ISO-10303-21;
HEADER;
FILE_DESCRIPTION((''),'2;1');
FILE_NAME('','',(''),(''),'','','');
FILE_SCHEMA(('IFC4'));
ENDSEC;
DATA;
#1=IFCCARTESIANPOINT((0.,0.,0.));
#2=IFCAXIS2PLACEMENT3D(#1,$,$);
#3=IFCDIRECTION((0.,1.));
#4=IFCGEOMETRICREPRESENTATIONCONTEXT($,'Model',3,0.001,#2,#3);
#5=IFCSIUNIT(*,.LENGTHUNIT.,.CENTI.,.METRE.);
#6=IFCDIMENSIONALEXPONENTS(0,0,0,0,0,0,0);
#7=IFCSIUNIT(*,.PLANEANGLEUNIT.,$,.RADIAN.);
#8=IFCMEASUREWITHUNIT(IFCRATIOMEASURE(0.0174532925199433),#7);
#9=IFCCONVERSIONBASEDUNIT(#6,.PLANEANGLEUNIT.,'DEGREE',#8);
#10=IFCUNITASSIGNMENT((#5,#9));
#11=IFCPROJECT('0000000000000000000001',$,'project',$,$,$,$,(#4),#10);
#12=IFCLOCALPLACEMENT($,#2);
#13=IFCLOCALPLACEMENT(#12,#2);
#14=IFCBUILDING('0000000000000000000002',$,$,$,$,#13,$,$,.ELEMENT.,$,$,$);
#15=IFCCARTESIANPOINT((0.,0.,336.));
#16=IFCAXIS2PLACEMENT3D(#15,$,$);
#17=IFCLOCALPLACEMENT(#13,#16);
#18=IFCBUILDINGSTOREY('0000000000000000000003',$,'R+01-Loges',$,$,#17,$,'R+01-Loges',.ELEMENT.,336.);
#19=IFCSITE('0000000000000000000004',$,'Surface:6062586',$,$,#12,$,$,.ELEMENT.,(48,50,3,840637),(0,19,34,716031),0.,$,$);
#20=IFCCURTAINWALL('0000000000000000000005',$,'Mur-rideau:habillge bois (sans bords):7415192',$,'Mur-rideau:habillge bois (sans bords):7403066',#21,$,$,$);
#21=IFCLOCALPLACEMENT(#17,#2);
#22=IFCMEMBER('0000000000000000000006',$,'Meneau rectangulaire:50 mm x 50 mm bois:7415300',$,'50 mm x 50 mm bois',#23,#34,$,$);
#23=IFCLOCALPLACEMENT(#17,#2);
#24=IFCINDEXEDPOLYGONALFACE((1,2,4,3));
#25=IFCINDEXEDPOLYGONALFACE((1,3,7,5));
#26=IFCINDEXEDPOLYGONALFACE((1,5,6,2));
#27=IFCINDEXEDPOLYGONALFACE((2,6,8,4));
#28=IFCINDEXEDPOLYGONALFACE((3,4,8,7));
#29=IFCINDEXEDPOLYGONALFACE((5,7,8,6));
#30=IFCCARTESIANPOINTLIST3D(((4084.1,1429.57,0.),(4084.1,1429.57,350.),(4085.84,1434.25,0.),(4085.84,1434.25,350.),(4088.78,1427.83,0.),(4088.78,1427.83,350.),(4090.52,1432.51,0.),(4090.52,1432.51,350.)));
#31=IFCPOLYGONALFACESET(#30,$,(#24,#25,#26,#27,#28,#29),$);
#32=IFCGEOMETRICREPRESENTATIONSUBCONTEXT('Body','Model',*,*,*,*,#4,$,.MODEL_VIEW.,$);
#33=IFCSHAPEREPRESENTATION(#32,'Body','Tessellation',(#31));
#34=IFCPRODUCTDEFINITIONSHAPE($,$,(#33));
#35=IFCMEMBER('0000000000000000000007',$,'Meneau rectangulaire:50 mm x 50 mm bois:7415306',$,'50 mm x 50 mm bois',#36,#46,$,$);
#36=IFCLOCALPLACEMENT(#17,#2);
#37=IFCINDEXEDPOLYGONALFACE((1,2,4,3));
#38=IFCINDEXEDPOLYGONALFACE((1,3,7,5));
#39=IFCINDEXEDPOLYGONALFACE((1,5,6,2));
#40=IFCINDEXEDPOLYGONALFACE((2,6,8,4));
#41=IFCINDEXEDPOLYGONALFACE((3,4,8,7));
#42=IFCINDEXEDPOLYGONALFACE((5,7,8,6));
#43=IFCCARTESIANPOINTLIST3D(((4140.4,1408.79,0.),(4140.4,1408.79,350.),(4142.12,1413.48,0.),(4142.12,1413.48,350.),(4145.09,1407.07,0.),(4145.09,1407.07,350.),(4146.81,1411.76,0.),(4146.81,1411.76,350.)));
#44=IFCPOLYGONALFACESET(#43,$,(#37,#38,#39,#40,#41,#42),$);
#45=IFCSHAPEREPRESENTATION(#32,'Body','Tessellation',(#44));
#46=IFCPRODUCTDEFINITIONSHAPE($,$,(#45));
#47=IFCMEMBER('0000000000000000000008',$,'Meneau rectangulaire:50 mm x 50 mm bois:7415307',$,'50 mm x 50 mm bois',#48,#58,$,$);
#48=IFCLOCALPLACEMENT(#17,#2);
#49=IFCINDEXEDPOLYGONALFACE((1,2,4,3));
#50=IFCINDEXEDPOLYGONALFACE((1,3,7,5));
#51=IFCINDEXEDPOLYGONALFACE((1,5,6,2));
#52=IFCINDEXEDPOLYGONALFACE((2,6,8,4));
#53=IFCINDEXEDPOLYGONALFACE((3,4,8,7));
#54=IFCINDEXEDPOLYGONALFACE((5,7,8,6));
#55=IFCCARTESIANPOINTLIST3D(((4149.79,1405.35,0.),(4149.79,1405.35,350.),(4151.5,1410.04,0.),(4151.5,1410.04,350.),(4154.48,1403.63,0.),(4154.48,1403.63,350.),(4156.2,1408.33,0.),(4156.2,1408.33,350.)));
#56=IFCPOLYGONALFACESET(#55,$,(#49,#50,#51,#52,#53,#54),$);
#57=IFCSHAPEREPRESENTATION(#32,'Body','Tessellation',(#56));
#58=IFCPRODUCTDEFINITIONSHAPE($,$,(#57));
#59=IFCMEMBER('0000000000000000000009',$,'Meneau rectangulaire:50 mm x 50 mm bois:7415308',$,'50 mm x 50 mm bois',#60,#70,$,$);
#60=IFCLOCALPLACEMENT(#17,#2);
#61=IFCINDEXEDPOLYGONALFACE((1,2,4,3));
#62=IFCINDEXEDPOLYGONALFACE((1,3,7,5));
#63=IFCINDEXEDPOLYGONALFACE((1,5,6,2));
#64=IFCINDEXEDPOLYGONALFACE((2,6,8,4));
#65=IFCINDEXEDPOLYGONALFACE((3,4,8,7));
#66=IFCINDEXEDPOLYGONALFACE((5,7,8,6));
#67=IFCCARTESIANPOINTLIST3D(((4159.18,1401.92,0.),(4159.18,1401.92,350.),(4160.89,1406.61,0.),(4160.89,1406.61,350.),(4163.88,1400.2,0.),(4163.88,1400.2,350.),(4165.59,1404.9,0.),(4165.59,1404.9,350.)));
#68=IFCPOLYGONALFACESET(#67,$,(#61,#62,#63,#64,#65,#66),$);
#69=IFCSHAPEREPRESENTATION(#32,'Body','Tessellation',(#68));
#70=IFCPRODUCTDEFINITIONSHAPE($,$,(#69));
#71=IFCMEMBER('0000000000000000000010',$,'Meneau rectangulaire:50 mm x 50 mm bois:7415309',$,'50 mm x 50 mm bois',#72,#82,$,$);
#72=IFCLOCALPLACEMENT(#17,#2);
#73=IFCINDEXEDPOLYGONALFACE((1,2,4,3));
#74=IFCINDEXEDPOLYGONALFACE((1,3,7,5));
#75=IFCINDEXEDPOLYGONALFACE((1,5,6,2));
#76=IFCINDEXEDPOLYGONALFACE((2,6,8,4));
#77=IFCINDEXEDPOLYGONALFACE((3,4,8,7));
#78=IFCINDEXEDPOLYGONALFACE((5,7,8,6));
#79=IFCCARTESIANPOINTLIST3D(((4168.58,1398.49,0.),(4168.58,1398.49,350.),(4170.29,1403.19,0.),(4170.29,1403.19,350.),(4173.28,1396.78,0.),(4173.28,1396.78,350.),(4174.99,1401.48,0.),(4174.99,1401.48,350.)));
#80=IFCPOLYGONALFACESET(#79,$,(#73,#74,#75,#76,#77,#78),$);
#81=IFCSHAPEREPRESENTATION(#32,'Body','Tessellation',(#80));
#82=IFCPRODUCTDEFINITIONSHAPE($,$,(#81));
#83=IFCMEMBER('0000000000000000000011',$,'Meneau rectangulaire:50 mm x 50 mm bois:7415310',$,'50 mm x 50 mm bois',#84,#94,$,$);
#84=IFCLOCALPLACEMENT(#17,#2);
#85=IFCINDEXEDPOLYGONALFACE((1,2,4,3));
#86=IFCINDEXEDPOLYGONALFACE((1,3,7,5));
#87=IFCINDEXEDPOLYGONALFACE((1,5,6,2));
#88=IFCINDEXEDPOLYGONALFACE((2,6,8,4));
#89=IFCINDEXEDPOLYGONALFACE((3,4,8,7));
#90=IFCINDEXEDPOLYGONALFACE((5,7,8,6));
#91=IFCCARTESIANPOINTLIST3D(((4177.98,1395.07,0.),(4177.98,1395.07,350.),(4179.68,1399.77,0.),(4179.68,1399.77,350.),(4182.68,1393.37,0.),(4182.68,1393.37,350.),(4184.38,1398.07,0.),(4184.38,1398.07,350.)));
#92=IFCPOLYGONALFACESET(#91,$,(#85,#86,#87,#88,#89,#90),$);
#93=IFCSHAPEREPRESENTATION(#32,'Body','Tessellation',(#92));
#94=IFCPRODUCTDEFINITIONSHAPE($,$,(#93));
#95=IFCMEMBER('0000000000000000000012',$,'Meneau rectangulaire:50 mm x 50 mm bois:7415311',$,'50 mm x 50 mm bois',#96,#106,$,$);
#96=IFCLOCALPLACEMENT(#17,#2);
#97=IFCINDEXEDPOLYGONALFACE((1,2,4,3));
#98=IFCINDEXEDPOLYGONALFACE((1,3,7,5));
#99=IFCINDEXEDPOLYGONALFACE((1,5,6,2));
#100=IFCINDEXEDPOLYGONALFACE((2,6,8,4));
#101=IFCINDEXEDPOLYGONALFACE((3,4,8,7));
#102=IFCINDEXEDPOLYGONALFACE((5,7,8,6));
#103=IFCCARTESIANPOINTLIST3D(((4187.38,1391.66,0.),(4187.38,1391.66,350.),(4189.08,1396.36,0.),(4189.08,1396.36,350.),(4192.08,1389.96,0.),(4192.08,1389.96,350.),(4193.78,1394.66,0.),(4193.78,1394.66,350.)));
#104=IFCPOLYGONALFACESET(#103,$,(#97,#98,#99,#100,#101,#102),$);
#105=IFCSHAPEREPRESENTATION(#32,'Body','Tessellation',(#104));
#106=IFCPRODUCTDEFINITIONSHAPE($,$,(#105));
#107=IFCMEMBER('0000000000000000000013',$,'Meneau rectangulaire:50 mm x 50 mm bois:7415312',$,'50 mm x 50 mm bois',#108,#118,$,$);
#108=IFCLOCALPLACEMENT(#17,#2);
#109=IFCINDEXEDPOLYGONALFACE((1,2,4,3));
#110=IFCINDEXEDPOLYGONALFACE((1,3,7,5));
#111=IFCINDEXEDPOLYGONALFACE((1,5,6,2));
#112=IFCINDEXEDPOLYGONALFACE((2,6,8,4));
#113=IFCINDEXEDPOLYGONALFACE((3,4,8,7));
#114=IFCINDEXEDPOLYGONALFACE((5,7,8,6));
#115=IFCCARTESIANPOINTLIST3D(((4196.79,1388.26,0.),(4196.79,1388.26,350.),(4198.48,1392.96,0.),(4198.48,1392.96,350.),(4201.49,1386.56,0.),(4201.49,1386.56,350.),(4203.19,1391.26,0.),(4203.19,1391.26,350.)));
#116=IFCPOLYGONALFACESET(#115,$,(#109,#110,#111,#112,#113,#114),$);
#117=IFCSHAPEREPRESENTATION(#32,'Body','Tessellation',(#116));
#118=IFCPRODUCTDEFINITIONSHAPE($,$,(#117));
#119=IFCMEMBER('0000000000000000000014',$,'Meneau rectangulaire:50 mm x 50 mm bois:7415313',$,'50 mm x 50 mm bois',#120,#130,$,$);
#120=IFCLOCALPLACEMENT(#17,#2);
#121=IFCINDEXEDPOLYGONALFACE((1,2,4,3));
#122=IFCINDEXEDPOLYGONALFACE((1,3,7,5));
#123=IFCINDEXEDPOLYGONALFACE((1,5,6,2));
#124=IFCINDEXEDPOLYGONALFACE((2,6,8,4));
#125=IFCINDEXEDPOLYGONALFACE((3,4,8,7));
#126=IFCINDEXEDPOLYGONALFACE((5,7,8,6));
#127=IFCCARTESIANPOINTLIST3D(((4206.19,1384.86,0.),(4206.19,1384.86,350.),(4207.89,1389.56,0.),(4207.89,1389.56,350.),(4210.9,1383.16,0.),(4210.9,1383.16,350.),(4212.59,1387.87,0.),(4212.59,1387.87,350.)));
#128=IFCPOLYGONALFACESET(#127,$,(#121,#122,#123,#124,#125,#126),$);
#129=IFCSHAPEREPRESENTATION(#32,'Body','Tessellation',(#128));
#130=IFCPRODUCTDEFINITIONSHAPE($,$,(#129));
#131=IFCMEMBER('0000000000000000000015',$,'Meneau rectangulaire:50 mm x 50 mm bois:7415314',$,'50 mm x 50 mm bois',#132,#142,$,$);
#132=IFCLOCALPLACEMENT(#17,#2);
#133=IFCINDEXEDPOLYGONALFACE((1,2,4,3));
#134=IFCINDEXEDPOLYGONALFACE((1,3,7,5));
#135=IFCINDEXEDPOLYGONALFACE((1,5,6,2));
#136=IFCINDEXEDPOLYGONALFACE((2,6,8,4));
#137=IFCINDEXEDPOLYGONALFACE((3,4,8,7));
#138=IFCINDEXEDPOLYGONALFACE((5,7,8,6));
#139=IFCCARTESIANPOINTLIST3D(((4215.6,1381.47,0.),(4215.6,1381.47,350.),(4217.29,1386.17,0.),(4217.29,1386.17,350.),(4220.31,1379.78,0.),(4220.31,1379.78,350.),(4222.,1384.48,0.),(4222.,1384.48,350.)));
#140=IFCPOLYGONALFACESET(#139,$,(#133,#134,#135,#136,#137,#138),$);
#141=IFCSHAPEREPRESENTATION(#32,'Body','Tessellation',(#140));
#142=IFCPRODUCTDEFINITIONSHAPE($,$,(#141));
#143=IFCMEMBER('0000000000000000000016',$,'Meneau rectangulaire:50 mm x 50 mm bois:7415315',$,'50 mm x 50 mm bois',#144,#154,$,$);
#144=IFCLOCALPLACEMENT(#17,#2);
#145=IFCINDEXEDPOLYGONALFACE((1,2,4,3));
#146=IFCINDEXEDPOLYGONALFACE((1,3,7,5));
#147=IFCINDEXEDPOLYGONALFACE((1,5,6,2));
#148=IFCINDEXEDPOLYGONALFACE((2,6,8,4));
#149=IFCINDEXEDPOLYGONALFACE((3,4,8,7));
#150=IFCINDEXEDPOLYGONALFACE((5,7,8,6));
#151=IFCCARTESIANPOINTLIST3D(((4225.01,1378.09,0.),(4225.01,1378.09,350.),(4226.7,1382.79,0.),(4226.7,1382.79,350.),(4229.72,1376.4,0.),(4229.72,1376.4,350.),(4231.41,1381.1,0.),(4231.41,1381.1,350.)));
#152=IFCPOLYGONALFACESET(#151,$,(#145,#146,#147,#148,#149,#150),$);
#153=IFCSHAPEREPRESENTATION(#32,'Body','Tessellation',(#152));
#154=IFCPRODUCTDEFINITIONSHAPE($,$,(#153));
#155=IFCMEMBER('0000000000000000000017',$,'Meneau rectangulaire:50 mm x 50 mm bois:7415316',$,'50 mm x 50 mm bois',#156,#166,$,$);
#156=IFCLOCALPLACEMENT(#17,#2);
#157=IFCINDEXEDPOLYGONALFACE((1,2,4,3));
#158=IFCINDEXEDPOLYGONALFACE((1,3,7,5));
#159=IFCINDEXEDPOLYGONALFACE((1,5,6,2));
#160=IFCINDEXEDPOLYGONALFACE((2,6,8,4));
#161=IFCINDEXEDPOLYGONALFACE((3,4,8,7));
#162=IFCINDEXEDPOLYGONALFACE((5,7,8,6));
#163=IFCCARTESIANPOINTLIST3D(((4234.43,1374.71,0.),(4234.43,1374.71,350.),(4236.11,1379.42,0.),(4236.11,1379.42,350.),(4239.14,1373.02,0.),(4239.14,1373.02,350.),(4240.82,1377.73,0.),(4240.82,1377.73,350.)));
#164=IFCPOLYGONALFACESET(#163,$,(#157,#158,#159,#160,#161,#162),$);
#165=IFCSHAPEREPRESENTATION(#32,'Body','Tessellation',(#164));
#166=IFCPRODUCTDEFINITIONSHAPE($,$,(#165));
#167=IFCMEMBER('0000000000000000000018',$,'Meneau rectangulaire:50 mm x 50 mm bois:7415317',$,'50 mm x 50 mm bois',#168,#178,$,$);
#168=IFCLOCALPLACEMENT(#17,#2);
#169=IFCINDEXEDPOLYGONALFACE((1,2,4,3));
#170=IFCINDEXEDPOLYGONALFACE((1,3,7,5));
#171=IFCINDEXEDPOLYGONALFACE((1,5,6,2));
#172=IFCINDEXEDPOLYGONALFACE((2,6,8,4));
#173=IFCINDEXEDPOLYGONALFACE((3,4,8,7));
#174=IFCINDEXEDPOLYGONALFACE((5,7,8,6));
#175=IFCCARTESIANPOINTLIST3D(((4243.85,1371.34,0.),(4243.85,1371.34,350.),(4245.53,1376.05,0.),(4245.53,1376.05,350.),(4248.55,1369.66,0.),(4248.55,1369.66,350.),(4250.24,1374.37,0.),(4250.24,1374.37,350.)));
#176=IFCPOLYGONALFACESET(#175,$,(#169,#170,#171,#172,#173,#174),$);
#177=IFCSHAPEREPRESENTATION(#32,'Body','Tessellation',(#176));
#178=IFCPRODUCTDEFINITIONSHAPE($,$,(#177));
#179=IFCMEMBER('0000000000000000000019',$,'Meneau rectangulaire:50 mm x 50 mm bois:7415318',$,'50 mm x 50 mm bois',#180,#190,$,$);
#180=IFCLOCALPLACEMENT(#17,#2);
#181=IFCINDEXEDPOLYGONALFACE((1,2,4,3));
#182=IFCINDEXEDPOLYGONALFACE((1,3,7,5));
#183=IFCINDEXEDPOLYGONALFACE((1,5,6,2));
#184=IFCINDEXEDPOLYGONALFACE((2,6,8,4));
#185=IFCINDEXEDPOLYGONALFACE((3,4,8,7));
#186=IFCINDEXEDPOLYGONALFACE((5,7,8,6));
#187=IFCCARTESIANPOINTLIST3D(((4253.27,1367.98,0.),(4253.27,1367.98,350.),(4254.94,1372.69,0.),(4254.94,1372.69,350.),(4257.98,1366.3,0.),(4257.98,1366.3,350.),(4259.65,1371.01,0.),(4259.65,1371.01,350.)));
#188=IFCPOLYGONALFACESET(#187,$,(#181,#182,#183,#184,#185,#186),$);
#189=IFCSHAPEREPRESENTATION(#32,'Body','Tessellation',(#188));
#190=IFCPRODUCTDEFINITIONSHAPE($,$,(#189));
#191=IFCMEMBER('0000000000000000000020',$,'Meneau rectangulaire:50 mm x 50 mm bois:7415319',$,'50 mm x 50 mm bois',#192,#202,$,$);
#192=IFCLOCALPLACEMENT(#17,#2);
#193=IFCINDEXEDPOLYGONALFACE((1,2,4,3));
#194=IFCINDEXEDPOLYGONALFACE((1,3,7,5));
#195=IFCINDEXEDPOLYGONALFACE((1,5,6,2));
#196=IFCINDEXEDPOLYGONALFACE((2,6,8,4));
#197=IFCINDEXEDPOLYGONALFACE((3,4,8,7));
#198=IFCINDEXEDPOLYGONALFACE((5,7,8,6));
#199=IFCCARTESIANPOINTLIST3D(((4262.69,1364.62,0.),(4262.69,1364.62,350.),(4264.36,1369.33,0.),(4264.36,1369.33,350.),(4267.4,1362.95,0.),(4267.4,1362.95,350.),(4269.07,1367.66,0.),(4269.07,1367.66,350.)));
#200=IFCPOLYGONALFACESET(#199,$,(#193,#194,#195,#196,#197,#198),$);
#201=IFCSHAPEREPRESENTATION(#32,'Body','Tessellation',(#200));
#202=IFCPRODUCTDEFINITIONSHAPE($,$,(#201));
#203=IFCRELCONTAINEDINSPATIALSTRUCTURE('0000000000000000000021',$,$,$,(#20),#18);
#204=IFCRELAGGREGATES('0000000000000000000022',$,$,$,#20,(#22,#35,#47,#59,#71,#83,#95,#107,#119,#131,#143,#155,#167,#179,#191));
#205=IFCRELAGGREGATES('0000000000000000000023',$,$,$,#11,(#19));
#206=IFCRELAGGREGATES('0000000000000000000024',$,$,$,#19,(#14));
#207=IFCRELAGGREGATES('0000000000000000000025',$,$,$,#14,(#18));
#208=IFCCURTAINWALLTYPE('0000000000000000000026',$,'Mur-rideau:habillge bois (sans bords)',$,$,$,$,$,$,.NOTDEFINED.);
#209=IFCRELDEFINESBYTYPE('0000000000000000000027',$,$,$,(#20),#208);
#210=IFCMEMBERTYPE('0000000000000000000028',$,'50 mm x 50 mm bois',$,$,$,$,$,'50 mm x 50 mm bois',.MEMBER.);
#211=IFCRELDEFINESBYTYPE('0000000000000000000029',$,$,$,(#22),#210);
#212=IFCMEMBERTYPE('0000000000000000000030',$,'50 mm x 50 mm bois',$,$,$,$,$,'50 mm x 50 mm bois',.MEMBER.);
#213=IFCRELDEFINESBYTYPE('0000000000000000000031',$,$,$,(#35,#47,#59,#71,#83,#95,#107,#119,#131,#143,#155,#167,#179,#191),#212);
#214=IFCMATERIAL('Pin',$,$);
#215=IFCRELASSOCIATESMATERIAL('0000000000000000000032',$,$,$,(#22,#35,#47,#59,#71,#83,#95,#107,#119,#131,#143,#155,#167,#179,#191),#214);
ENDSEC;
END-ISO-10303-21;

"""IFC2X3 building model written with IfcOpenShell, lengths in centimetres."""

from ifc_helpers import new_model, entity, si_unit, converted_unit, direction, frame, origin, origin_2d_with_axis, place, context, subcontext, project, spatial, rectangle, extrude, source, transform, mapped, material, type_object, type_shapes, element, aggregate, save


model = new_model("IFC2X3")

# Units and contexts
model_context = context("Model", 3, precision=0.001, world=origin(), true_north=direction((0.0, 1.0)))
body_context = subcontext(model_context, "Body", "Model", "MODEL_VIEW")
ifc_project = project(units=[si_unit("LENGTHUNIT", "METRE", prefix="CENTI"), converted_unit("PLANEANGLEUNIT", "DEGREE", entity("IfcRatioMeasure", 0.0174532925199433), si_unit("PLANEANGLEUNIT", "RADIAN"), dimensions=[0, 0, 0, 0, 0, 0, 0])], contexts=[model_context])

# Site, building, storey
site_placement = place(None, origin())
site = spatial("IfcSite", under=ifc_project, at=site_placement, Name="Surface:6062586", CompositionType="ELEMENT", RefLatitude=(48, 50, 3, 840637), RefLongitude=(0, 19, 34, 716031), RefElevation=0.0)
building_placement = place(site_placement, origin())
building = spatial("IfcBuilding", under=site, at=building_placement, CompositionType="ELEMENT")
storey_placement = place(building_placement, frame((0.0, 0.0, 336.0)))
storey = spatial("IfcBuildingStorey", under=building, at=storey_placement, Name="R+01-Loges", LongName="R+01-Loges", CompositionType="ELEMENT", Elevation=336.0)

# Curtain wall, members
curtain_wall_type = type_object("IfcCurtainWallType", Name="Mur-rideau:habillge bois (sans bords)", PredefinedType="NOTDEFINED")
curtain_wall_placement = place(storey_placement, frame((0.0, 0.0, -336.0)))
curtain_wall = element("IfcCurtainWall", 1, at=curtain_wall_placement, inside=storey, type_object=curtain_wall_type, Name="Mur-rideau:habillge bois (sans bords):7415192", ObjectType="Mur-rideau:habillge bois (sans bords):7403066")
ifc_material_1 = material(Name="Pin")
member_type_1 = type_object("IfcMemberType", Name="50 mm x 50 mm bois", ElementType="50 mm x 50 mm bois", PredefinedType="MEMBER")
shared_shape_1 = source(origin(), body_context, "Body", "SweptSolid", [
    extrude(rectangle(XDim=5.0, YDim=5.0, at=origin_2d_with_axis()), frame((-2.5, 0.0, -350.0), z_axis=(0.0, 0.0, 1.0), x_axis=(0.0, -1.0, 0.0)), (0.0, 0.0, 1.0), 350.0),
])
type_shapes(member_type_1, [shared_shape_1])
member_1_placement = place(storey_placement, frame((4084.97, 1431.91, 350.0), z_axis=(0.0, 0.0, 1.0), x_axis=(-0.937536, 0.347889, 0.0)))
member_1 = element("IfcMember", 2, at=member_1_placement, type_object=member_type_1, material=ifc_material_1, Name="Meneau rectangulaire:50 mm x 50 mm bois:7415300", ObjectType="50 mm x 50 mm bois", context=body_context, shape_type="MappedRepresentation", body=[
    mapped(shared_shape_1, transform((0.0, 0.0, 0.0), scale=1.0)),
])
member_type_2 = type_object("IfcMemberType", Name="50 mm x 50 mm bois", ElementType="50 mm x 50 mm bois", PredefinedType="MEMBER")
shared_shape_2 = source(origin(), body_context, "Body", "SweptSolid", [
    extrude(rectangle(XDim=5.0, YDim=5.0, at=origin_2d_with_axis()), frame((0.0, 0.0, -350.0), z_axis=(0.0, 0.0, 1.0), x_axis=(0.0, -1.0, 0.0)), (0.0, 0.0, 1.0), 350.0),
])
type_shapes(member_type_2, [shared_shape_2])
member_2_placement = place(storey_placement, frame((4143.6, 1410.28, 0.0), z_axis=(0.0, 0.0, -1.0), x_axis=(0.938967, -0.344006, 0.0)))
member_2 = element("IfcMember", 3, at=member_2_placement, type_object=member_type_2, material=ifc_material_1, Name="Meneau rectangulaire:50 mm x 50 mm bois:7415306", ObjectType="50 mm x 50 mm bois", context=body_context, shape_type="MappedRepresentation", body=[
    mapped(shared_shape_2, transform((0.0, 0.0, 0.0), scale=1.0)),
])
member_3_placement = place(storey_placement, frame((4152.99, 1406.84, 0.0), z_axis=(0.0, 0.0, -1.0), x_axis=(0.93922, -0.343315, 0.0)))
member_3 = element("IfcMember", 4, at=member_3_placement, type_object=member_type_2, material=ifc_material_1, Name="Meneau rectangulaire:50 mm x 50 mm bois:7415307", ObjectType="50 mm x 50 mm bois", context=body_context, shape_type="MappedRepresentation", body=[
    mapped(shared_shape_2, transform((0.0, 0.0, 0.0), scale=1.0)),
])
member_4_placement = place(storey_placement, frame((4162.39, 1403.41, 0.0), z_axis=(0.0, 0.0, -1.0), x_axis=(0.939473, -0.342624, 0.0)))
member_4 = element("IfcMember", 5, at=member_4_placement, type_object=member_type_2, material=ifc_material_1, Name="Meneau rectangulaire:50 mm x 50 mm bois:7415308", ObjectType="50 mm x 50 mm bois", context=body_context, shape_type="MappedRepresentation", body=[
    mapped(shared_shape_2, transform((0.0, 0.0, 0.0), scale=1.0)),
])
member_5_placement = place(storey_placement, frame((4171.78, 1399.99, 0.0), z_axis=(0.0, 0.0, -1.0), x_axis=(0.939725, -0.341932, 0.0)))
member_5 = element("IfcMember", 6, at=member_5_placement, type_object=member_type_2, material=ifc_material_1, Name="Meneau rectangulaire:50 mm x 50 mm bois:7415309", ObjectType="50 mm x 50 mm bois", context=body_context, shape_type="MappedRepresentation", body=[
    mapped(shared_shape_2, transform((0.0, 0.0, 0.0), scale=1.0)),
])
member_6_placement = place(storey_placement, frame((4181.18, 1396.57, 0.0), z_axis=(0.0, 0.0, -1.0), x_axis=(0.939976, -0.341241, 0.0)))
member_6 = element("IfcMember", 7, at=member_6_placement, type_object=member_type_2, material=ifc_material_1, Name="Meneau rectangulaire:50 mm x 50 mm bois:7415310", ObjectType="50 mm x 50 mm bois", context=body_context, shape_type="MappedRepresentation", body=[
    mapped(shared_shape_2, transform((0.0, 0.0, 0.0), scale=1.0)),
])
member_7_placement = place(storey_placement, frame((4190.58, 1393.16, 0.0), z_axis=(0.0, 0.0, -1.0), x_axis=(0.940227, -0.340549, 0.0)))
member_7 = element("IfcMember", 8, at=member_7_placement, type_object=member_type_2, material=ifc_material_1, Name="Meneau rectangulaire:50 mm x 50 mm bois:7415311", ObjectType="50 mm x 50 mm bois", context=body_context, shape_type="MappedRepresentation", body=[
    mapped(shared_shape_2, transform((0.0, 0.0, 0.0), scale=1.0)),
])
member_8_placement = place(storey_placement, frame((4199.99, 1389.76, 0.0), z_axis=(0.0, 0.0, -1.0), x_axis=(0.940477, -0.339857, 0.0)))
member_8 = element("IfcMember", 9, at=member_8_placement, type_object=member_type_2, material=ifc_material_1, Name="Meneau rectangulaire:50 mm x 50 mm bois:7415312", ObjectType="50 mm x 50 mm bois", context=body_context, shape_type="MappedRepresentation", body=[
    mapped(shared_shape_2, transform((0.0, 0.0, 0.0), scale=1.0)),
])
member_9_placement = place(storey_placement, frame((4209.39, 1386.36, 0.0), z_axis=(0.0, 0.0, -1.0), x_axis=(0.940727, -0.339165, 0.0)))
member_9 = element("IfcMember", 10, at=member_9_placement, type_object=member_type_2, material=ifc_material_1, Name="Meneau rectangulaire:50 mm x 50 mm bois:7415313", ObjectType="50 mm x 50 mm bois", context=body_context, shape_type="MappedRepresentation", body=[
    mapped(shared_shape_2, transform((0.0, 0.0, 0.0), scale=1.0)),
])
member_10_placement = place(storey_placement, frame((4218.8, 1382.98, 0.0), z_axis=(0.0, 0.0, -1.0), x_axis=(0.940976, -0.338473, 0.0)))
member_10 = element("IfcMember", 11, at=member_10_placement, type_object=member_type_2, material=ifc_material_1, Name="Meneau rectangulaire:50 mm x 50 mm bois:7415314", ObjectType="50 mm x 50 mm bois", context=body_context, shape_type="MappedRepresentation", body=[
    mapped(shared_shape_2, transform((0.0, 0.0, 0.0), scale=1.0)),
])
member_11_placement = place(storey_placement, frame((4228.21, 1379.59, 0.0), z_axis=(0.0, 0.0, -1.0), x_axis=(0.941225, -0.33778, 0.0)))
member_11 = element("IfcMember", 12, at=member_11_placement, type_object=member_type_2, material=ifc_material_1, Name="Meneau rectangulaire:50 mm x 50 mm bois:7415315", ObjectType="50 mm x 50 mm bois", context=body_context, shape_type="MappedRepresentation", body=[
    mapped(shared_shape_2, transform((0.0, 0.0, 0.0), scale=1.0)),
])
member_12_placement = place(storey_placement, frame((4237.63, 1376.22, 0.0), z_axis=(0.0, 0.0, -1.0), x_axis=(0.941473, -0.337088, 0.0)))
member_12 = element("IfcMember", 13, at=member_12_placement, type_object=member_type_2, material=ifc_material_1, Name="Meneau rectangulaire:50 mm x 50 mm bois:7415316", ObjectType="50 mm x 50 mm bois", context=body_context, shape_type="MappedRepresentation", body=[
    mapped(shared_shape_2, transform((0.0, 0.0, 0.0), scale=1.0)),
])
member_13_placement = place(storey_placement, frame((4247.04, 1372.85, 0.0), z_axis=(0.0, 0.0, -1.0), x_axis=(0.941721, -0.336395, 0.0)))
member_13 = element("IfcMember", 14, at=member_13_placement, type_object=member_type_2, material=ifc_material_1, Name="Meneau rectangulaire:50 mm x 50 mm bois:7415317", ObjectType="50 mm x 50 mm bois", context=body_context, shape_type="MappedRepresentation", body=[
    mapped(shared_shape_2, transform((0.0, 0.0, 0.0), scale=1.0)),
])
member_14_placement = place(storey_placement, frame((4256.46, 1369.49, 0.0), z_axis=(0.0, 0.0, -1.0), x_axis=(0.941968, -0.335702, 0.0)))
member_14 = element("IfcMember", 15, at=member_14_placement, type_object=member_type_2, material=ifc_material_1, Name="Meneau rectangulaire:50 mm x 50 mm bois:7415318", ObjectType="50 mm x 50 mm bois", context=body_context, shape_type="MappedRepresentation", body=[
    mapped(shared_shape_2, transform((0.0, 0.0, 0.0), scale=1.0)),
])
member_15_placement = place(storey_placement, frame((4265.88, 1366.14, 0.0), z_axis=(0.0, 0.0, -1.0), x_axis=(0.942215, -0.335009, 0.0)))
member_15 = element("IfcMember", 16, at=member_15_placement, type_object=member_type_2, material=ifc_material_1, Name="Meneau rectangulaire:50 mm x 50 mm bois:7415319", ObjectType="50 mm x 50 mm bois", context=body_context, shape_type="MappedRepresentation", body=[
    mapped(shared_shape_2, transform((0.0, 0.0, 0.0), scale=1.0)),
])
aggregate(curtain_wall, [member_1, member_2, member_3, member_4, member_5, member_6, member_7, member_8, member_9, member_10, member_11, member_12, member_13, member_14, member_15])

save(model, "model.ifc")
